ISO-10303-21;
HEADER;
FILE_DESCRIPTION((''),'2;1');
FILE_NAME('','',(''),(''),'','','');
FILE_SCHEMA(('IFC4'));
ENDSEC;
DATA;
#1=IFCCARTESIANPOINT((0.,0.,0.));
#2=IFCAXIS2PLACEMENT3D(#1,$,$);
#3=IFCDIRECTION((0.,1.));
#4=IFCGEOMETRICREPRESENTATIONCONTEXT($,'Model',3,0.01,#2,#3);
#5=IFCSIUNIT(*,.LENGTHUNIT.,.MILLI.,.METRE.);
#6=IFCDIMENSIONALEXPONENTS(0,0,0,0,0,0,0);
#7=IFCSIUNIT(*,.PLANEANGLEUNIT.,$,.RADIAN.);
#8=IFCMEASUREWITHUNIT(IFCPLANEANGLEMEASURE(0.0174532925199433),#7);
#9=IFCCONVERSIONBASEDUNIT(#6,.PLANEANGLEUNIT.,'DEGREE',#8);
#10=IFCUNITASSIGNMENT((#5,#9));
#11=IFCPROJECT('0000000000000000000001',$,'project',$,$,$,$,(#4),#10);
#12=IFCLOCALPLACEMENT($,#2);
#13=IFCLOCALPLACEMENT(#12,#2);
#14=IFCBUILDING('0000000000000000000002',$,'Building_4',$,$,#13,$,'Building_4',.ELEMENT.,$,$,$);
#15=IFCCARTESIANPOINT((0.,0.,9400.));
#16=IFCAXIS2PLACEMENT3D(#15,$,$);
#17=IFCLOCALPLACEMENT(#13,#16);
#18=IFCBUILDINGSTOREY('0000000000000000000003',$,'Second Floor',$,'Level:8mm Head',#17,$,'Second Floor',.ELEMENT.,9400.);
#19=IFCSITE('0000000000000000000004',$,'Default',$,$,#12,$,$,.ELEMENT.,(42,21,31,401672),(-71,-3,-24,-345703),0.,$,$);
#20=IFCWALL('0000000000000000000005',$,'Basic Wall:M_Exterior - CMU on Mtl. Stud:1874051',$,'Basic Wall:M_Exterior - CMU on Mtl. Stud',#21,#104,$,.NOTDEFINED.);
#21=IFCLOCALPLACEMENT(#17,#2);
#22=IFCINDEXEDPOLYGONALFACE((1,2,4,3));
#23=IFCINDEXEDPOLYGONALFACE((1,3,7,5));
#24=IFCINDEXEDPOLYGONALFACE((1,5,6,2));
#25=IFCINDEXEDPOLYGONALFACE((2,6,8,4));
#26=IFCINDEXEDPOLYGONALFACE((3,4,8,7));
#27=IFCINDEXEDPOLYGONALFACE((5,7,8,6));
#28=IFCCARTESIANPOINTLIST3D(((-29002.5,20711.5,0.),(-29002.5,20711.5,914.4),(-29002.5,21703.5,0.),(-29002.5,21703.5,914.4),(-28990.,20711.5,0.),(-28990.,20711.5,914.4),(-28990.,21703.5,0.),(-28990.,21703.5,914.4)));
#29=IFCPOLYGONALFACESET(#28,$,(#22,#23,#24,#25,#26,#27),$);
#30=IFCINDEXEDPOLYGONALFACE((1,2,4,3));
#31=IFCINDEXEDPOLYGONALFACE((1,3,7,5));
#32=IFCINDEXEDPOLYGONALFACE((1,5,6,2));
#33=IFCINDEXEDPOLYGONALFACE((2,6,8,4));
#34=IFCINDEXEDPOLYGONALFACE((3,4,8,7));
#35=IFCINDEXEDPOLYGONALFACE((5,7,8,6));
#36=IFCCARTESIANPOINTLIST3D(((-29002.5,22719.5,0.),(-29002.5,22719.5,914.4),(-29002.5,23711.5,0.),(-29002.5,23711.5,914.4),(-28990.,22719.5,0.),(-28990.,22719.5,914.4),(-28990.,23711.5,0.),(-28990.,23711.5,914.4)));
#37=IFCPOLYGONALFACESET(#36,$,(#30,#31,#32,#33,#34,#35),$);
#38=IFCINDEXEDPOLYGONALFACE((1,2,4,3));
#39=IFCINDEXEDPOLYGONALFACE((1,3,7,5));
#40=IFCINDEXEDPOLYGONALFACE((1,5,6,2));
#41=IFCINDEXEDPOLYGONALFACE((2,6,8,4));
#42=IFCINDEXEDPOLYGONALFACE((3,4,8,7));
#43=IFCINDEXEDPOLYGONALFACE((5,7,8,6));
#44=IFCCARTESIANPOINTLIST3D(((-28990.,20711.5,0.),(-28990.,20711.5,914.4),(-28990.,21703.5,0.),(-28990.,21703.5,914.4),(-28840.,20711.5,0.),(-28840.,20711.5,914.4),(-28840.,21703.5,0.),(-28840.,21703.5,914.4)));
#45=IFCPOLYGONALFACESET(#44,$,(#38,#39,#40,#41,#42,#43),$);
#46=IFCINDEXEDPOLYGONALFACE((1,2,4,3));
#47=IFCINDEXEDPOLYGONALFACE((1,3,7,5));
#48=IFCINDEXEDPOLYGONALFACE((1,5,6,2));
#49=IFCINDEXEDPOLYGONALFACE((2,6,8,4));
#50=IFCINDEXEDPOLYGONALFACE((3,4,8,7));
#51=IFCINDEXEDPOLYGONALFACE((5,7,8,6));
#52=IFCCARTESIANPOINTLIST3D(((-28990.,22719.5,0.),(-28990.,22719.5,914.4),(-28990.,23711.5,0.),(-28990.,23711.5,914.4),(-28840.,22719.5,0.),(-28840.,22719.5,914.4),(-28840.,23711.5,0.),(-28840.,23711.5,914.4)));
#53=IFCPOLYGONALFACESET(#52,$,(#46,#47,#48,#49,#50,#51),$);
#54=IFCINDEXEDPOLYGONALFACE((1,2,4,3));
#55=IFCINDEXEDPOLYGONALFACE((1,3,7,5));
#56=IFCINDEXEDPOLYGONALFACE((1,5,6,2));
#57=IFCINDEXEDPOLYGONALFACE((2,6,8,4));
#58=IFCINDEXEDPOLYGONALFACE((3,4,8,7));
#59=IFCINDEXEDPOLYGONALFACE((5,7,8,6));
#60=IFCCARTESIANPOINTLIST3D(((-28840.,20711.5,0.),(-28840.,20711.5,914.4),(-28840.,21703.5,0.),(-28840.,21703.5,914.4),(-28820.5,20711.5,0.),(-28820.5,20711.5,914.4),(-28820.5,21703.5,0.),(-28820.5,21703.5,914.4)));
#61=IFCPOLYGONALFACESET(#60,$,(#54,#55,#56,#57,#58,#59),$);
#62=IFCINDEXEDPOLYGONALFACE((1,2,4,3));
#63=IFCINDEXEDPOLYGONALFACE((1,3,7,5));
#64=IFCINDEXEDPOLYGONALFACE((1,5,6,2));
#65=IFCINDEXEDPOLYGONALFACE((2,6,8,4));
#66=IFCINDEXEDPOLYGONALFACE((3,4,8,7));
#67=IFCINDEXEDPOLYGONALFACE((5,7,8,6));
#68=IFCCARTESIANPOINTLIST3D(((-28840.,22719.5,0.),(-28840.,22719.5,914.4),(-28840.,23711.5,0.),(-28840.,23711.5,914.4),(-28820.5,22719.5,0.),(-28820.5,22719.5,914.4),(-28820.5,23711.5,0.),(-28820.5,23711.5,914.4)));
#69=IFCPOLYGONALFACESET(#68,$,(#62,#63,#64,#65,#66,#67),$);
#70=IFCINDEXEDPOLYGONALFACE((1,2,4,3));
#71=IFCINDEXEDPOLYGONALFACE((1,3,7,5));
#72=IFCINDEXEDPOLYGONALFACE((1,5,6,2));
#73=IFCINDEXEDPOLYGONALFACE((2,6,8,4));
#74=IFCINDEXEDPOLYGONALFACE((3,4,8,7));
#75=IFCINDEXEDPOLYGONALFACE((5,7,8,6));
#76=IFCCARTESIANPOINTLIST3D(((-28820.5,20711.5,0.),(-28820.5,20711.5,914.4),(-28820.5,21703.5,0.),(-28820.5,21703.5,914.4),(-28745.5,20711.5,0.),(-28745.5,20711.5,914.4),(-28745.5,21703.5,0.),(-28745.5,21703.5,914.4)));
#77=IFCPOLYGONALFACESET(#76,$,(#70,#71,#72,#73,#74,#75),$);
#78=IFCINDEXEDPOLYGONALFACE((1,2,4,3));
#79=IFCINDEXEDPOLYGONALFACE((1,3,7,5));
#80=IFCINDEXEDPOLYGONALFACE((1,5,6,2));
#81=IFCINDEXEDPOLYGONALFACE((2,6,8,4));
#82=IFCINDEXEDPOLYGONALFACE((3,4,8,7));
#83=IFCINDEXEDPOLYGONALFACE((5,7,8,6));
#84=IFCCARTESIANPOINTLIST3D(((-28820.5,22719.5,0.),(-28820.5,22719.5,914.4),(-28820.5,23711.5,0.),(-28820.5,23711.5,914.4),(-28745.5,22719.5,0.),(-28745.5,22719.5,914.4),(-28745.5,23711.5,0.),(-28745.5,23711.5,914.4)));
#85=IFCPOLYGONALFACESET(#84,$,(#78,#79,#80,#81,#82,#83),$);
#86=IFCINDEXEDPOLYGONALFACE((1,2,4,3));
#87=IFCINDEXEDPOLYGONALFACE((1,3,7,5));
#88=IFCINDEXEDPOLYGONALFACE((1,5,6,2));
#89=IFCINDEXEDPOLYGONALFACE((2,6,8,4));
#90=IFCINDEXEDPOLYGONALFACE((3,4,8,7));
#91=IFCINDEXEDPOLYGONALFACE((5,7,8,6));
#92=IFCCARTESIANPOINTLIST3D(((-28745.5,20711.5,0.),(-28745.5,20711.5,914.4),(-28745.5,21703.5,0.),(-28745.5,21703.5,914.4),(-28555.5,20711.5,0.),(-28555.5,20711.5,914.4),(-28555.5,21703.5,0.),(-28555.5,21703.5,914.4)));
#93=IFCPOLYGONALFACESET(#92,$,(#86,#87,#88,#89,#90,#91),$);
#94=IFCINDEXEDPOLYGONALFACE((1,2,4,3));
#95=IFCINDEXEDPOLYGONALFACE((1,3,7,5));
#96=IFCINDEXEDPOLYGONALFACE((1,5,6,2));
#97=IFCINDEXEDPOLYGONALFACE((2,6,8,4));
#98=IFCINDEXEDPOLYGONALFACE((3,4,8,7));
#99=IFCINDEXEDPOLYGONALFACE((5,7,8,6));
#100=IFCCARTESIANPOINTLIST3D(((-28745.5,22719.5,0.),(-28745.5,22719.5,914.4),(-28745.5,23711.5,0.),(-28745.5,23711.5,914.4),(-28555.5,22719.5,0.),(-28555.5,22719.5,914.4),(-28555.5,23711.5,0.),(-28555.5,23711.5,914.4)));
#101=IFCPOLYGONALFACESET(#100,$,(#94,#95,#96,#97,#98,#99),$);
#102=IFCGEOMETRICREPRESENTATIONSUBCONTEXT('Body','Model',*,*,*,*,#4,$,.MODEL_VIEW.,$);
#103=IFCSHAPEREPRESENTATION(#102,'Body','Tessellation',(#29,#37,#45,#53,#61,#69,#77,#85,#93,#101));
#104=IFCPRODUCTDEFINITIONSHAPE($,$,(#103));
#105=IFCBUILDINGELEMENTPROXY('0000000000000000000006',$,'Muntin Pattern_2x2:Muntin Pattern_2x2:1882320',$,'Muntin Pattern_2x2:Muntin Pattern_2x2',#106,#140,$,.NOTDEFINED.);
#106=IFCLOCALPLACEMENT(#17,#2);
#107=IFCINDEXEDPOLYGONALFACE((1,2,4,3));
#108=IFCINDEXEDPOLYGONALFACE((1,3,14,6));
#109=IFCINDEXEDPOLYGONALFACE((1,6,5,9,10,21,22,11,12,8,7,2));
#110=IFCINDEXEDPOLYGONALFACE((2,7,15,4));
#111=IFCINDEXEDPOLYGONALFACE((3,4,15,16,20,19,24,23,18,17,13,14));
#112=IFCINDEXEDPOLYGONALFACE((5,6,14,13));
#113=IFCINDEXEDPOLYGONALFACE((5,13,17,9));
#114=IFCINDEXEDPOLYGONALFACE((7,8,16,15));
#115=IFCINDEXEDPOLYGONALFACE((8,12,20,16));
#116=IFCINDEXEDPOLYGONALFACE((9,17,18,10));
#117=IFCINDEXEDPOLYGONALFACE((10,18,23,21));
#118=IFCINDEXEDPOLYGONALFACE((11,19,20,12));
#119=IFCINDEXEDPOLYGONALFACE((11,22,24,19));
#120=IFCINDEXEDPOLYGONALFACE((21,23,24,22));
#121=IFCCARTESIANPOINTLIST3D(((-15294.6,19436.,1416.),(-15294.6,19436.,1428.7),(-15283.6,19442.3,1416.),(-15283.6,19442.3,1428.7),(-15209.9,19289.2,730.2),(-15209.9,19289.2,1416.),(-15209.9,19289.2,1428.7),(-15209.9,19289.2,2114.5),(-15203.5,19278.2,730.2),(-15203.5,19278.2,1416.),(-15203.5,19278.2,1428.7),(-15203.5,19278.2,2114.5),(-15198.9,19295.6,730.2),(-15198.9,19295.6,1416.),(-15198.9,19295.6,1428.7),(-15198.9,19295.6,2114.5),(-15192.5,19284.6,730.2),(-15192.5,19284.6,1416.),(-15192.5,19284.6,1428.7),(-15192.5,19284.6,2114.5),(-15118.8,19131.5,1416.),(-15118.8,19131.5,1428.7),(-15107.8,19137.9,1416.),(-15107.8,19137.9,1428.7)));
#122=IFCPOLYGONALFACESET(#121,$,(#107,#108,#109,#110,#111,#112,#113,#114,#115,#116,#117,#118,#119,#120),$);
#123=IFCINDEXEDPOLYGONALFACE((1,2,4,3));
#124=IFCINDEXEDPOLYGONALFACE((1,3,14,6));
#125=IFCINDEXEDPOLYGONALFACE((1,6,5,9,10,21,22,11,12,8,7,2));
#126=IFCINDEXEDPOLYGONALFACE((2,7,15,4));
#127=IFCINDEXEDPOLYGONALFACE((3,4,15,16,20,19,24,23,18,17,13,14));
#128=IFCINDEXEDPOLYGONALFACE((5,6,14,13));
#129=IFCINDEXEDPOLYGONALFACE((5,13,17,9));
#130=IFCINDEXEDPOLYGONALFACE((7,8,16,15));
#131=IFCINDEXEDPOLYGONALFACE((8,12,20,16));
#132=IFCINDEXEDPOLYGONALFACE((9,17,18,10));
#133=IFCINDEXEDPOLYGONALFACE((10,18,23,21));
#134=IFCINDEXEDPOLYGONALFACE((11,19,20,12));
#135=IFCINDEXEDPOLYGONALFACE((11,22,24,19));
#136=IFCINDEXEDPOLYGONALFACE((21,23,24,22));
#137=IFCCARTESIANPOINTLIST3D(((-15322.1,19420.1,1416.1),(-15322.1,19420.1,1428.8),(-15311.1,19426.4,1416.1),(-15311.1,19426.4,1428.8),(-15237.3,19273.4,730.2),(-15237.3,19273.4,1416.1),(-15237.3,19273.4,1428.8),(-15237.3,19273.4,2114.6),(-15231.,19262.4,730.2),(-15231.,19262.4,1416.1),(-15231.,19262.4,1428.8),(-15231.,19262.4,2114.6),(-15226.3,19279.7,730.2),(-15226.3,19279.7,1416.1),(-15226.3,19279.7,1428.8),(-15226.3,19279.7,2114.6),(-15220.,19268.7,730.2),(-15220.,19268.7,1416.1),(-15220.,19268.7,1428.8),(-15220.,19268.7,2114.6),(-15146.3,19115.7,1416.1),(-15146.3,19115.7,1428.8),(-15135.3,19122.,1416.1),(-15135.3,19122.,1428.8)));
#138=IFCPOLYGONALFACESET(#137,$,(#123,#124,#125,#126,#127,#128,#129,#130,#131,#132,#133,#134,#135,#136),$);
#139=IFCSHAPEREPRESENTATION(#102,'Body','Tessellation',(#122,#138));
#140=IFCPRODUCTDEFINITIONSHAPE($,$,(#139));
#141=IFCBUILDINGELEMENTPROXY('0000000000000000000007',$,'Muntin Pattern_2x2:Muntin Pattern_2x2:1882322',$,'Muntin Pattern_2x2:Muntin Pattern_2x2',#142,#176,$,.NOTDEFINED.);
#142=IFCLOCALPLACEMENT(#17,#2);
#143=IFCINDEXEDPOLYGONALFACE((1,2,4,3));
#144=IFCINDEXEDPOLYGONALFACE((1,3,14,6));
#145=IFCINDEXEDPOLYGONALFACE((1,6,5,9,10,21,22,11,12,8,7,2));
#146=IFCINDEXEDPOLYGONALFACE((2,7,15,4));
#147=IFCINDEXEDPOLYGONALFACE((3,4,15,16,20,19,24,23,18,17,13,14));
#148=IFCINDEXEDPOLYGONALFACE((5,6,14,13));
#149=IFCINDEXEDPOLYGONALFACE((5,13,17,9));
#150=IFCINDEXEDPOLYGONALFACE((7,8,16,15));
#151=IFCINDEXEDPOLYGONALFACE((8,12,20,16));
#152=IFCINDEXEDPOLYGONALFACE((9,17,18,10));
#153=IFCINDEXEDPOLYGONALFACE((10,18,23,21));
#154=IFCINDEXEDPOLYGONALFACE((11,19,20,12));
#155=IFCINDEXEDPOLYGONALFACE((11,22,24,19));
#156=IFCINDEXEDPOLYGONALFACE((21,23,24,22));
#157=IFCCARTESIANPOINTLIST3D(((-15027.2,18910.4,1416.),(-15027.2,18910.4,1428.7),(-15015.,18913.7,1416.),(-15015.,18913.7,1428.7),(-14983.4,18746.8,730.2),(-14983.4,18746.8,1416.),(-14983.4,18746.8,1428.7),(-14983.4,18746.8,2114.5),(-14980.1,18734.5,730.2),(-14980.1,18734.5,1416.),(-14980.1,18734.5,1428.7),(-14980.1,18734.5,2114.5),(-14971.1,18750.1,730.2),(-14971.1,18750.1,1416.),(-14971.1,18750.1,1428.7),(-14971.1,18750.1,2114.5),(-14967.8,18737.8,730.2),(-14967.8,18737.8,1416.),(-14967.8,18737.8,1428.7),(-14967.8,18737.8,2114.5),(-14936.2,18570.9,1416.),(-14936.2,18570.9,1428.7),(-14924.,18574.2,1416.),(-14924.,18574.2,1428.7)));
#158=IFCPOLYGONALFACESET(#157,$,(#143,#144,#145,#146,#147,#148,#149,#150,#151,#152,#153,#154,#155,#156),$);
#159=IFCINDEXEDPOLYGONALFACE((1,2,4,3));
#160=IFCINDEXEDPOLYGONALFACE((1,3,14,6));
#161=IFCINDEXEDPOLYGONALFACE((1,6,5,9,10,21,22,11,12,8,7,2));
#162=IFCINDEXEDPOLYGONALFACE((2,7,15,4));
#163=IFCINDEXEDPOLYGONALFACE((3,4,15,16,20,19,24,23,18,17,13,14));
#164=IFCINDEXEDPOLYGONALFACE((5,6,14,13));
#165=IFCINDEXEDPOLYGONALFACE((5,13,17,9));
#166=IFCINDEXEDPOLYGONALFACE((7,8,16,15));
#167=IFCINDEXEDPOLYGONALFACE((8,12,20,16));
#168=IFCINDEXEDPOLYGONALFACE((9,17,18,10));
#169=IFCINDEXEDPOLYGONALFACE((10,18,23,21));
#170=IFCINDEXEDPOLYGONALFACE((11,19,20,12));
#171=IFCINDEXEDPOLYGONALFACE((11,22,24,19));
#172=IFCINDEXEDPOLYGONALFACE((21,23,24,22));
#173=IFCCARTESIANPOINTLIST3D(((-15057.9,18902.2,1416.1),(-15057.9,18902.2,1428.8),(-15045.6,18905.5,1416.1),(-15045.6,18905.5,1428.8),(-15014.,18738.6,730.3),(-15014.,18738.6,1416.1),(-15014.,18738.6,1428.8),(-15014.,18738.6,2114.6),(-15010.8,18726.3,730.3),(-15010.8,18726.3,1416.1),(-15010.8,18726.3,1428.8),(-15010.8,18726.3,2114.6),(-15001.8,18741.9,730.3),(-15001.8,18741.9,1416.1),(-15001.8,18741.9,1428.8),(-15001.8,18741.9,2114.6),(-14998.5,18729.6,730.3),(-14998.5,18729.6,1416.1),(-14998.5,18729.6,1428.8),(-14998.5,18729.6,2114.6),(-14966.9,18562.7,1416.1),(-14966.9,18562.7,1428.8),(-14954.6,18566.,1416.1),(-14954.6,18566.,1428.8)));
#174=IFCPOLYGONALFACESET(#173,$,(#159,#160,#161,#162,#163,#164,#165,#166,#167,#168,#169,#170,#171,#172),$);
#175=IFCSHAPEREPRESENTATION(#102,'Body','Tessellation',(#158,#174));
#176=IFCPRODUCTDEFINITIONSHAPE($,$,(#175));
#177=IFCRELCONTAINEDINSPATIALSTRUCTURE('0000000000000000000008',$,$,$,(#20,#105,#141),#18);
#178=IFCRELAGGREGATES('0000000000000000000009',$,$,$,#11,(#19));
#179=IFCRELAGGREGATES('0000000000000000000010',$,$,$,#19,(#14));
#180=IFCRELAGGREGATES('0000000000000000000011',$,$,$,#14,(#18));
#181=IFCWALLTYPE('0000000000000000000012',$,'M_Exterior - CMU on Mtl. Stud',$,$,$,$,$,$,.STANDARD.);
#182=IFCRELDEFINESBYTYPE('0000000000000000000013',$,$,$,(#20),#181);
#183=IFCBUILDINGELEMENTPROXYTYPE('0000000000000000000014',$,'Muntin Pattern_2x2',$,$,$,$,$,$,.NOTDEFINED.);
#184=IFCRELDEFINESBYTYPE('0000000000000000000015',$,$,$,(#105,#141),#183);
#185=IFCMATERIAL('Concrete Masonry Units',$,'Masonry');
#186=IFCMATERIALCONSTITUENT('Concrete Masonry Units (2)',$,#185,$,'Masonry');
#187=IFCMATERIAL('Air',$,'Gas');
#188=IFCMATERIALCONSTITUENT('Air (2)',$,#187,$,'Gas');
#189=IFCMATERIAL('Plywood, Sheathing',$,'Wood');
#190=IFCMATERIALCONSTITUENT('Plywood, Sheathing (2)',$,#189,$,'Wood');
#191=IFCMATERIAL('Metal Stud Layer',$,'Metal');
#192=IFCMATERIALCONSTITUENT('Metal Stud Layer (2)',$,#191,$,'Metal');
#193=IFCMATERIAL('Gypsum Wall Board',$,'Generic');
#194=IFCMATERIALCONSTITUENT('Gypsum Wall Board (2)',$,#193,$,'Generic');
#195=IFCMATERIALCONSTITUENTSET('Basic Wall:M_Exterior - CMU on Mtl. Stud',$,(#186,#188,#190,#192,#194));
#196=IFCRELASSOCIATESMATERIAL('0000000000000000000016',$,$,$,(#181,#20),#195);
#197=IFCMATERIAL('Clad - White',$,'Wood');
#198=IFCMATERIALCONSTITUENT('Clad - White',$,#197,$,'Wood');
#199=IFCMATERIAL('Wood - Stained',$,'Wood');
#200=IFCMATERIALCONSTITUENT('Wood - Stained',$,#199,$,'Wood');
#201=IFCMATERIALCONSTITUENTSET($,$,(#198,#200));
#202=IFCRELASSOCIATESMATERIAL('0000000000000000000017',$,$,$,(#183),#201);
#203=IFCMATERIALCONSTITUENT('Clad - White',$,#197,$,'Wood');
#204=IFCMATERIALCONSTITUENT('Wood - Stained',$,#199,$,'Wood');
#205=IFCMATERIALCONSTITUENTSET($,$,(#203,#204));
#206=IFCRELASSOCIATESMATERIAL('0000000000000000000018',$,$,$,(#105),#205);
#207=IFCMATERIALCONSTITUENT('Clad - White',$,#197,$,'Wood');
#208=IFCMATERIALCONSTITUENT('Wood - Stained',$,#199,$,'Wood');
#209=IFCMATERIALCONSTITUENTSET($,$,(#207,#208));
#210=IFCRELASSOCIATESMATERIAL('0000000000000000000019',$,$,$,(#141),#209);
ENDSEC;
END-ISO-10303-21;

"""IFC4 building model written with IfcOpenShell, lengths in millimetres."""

from ifc_helpers import new_model, entity, si_unit, converted_unit, direction, frame, origin, place, context, subcontext, project, spatial, indexed_curve, outline, extrude, source, transform, mapped, material, constituent, constituent_set, type_object, type_shapes, element, save


model = new_model("IFC4")

# Units and contexts
model_context = context("Model", 3, precision=0.01, world=origin(), true_north=direction((0.0, 1.0)))
body_context = subcontext(model_context, "Body", "Model", "MODEL_VIEW")
ifc_project = project(units=[si_unit("LENGTHUNIT", "METRE", prefix="MILLI"), converted_unit("PLANEANGLEUNIT", "DEGREE", entity("IfcPlaneAngleMeasure", 0.0174532925199433), si_unit("PLANEANGLEUNIT", "RADIAN"), dimensions=[0, 0, 0, 0, 0, 0, 0])], contexts=[model_context])

# Site, building, storey
site_placement = place(None, origin())
site = spatial("IfcSite", under=ifc_project, at=site_placement, Name="Default", CompositionType="ELEMENT", RefLatitude=(42, 21, 31, 401672), RefLongitude=(-71, -3, -24, -345703), RefElevation=0.0)
building_placement = place(site_placement, origin())
building = spatial("IfcBuilding", under=site, at=building_placement, Name="Building_4", LongName="Building_4", CompositionType="ELEMENT")
storey_placement = place(building_placement, frame((0.0, 0.0, 9400.0)))
storey = spatial("IfcBuildingStorey", under=building, at=storey_placement, Name="Second Floor", ObjectType="Level:8mm Head", LongName="Second Floor", CompositionType="ELEMENT", Elevation=9400.0)

# Shared definitions
ifc_material_1 = material(Name="Air", Category="Gas")
ifc_material_2 = material(Name="Plywood, Sheathing", Category="Wood")
ifc_material_3 = material(Name="Metal Stud Layer", Category="Metal")
ifc_material_4 = material(Name="Gypsum Wall Board", Category="Generic")

# Wall, opening
ifc_material_5 = material(Name="Concrete Masonry Units", Category="Masonry")
ifc_constituent_1 = constituent(ifc_material_5, Name="Concrete Masonry Units (2)", Category="Masonry")
ifc_constituent_2 = constituent(ifc_material_1, Name="Air (2)", Category="Gas")
ifc_constituent_3 = constituent(ifc_material_2, Name="Plywood, Sheathing (2)", Category="Wood")
ifc_constituent_4 = constituent(ifc_material_3, Name="Metal Stud Layer (2)", Category="Metal")
ifc_constituent_5 = constituent(ifc_material_4, Name="Gypsum Wall Board (2)", Category="Generic")
ifc_constituent_set_1 = constituent_set(constituents=[ifc_constituent_1, ifc_constituent_2, ifc_constituent_3, ifc_constituent_4, ifc_constituent_5], Name="Basic Wall:M_Exterior - CMU on Mtl. Stud")
wall_type_1 = type_object("IfcWallType", Name="M_Exterior - CMU on Mtl. Stud", PredefinedType="STANDARD", material=ifc_constituent_set_1)
wall_1_placement = place(storey_placement, frame((-28779.0, 23711.5, 0.0), z_axis=(0.0, 0.0, 1.0), x_axis=(0.0, -1.0, 0.0)))
wall_1 = element("IfcWall", 1, at=wall_1_placement, inside=storey, type_object=wall_type_1, material=ifc_constituent_set_1, Name="Basic Wall:M_Exterior - CMU on Mtl. Stud:1874051", ObjectType="Basic Wall:M_Exterior - CMU on Mtl. Stud", PredefinedType="NOTDEFINED", context=body_context, shape_type="SweptSolid", body=[
    extrude(outline(indexed_curve([(-6.2, -496.0), (6.2, -496.0), (6.2, 496.0), (-6.2, 496.0), (-6.2, -496.0)], self_intersect=False)), frame((2504.0, -217.2, 0.0), z_axis=(0.0, 0.0, 1.0), x_axis=(0.0, 1.0, 0.0)), (0.0, 0.0, 1.0), 914.4),
    extrude(outline(indexed_curve([(-6.2, -496.0), (6.2, -496.0), (6.2, 496.0), (-6.2, 496.0), (-6.2, -496.0)], self_intersect=False)), frame((496.0, -217.2, 0.0), z_axis=(0.0, 0.0, 1.0), x_axis=(0.0, 1.0, 0.0)), (0.0, 0.0, 1.0), 914.4),
    extrude(outline(indexed_curve([(-496.0, -75.0), (496.0, -75.0), (496.0, 75.0), (-496.0, 75.0), (-496.0, -75.0)], self_intersect=False)), frame((2504.0, -136.0, 0.0)), (0.0, 0.0, 1.0), 914.4),
    extrude(outline(indexed_curve([(-496.0, -75.0), (496.0, -75.0), (496.0, 75.0), (-496.0, 75.0), (-496.0, -75.0)], self_intersect=False)), frame((496.0, -136.0, 0.0)), (0.0, 0.0, 1.0), 914.4),
    extrude(outline(indexed_curve([(-496.0, -9.7), (496.0, -9.7), (496.0, 9.8), (-496.0, 9.8), (-496.0, -9.7)], self_intersect=False)), frame((2504.0, -51.3, 0.0)), (0.0, 0.0, 1.0), 914.4),
    extrude(outline(indexed_curve([(-496.0, -9.7), (496.0, -9.7), (496.0, 9.8), (-496.0, 9.8), (-496.0, -9.7)], self_intersect=False)), frame((496.0, -51.3, 0.0)), (0.0, 0.0, 1.0), 914.4),
    extrude(outline(indexed_curve([(-496.0, -37.5), (496.0, -37.5), (496.0, 37.5), (-496.0, 37.5), (-496.0, -37.5)], self_intersect=False)), frame((2504.0, -4.0, 0.0)), (0.0, 0.0, 1.0), 914.4),
    extrude(outline(indexed_curve([(-496.0, -37.5), (496.0, -37.5), (496.0, 37.5), (-496.0, 37.5), (-496.0, -37.5)], self_intersect=False)), frame((496.0, -4.0, 0.0)), (0.0, 0.0, 1.0), 914.4),
    extrude(outline(indexed_curve([(-95.0, -496.0), (95.0, -496.0), (95.0, 496.0), (-95.0, 496.0), (-95.0, -496.0)], self_intersect=False)), frame((2504.0, 128.5, 0.0), z_axis=(0.0, 0.0, 1.0), x_axis=(0.0, -1.0, 0.0)), (0.0, 0.0, 1.0), 914.4),
    extrude(outline(indexed_curve([(-95.0, -496.0), (95.0, -496.0), (95.0, 496.0), (-95.0, 496.0), (-95.0, -496.0)], self_intersect=False)), frame((496.0, 128.5, 0.0), z_axis=(0.0, 0.0, 1.0), x_axis=(0.0, -1.0, 0.0)), (0.0, 0.0, 1.0), 914.4),
])
opening_1_placement = place(wall_1_placement, origin())
element("IfcOpeningElement", 2, at=opening_1_placement, cuts=wall_1, PredefinedType="OPENING", context=body_context, shape_type="SweptSolid", body=[
    extrude(outline(indexed_curve([(-508.0, -1117.6), (508.0, -1117.6), (508.0, 1117.6), (-508.0, 1117.6), (-508.0, -1117.6)], self_intersect=False)), frame((1500.0, -1747.5, 1117.6), z_axis=(0.0, 1.0, 0.0), x_axis=(-1.0, 0.0, 0.0)), (0.0, 0.0, 1.0), 3048.0),
])

# Building element proxies
ifc_material_6 = material(Name="Clad - White", Category="Wood")
ifc_constituent_6 = constituent(ifc_material_6, Name="Clad - White", Category="Wood")
ifc_material_7 = material(Name="Wood - Stained", Category="Wood")
ifc_constituent_7 = constituent(ifc_material_7, Name="Wood - Stained", Category="Wood")
ifc_constituent_set_2 = constituent_set(constituents=[ifc_constituent_6, ifc_constituent_7])
ifc_constituent_8 = constituent(ifc_material_6, Name="Clad - White", Category="Wood")
ifc_constituent_9 = constituent(ifc_material_7, Name="Wood - Stained", Category="Wood")
ifc_constituent_set_3 = constituent_set(constituents=[ifc_constituent_8, ifc_constituent_9])
building_element_proxy_type_1 = type_object("IfcBuildingElementProxyType", Name="Muntin Pattern_2x2", PredefinedType="NOTDEFINED", material=ifc_constituent_set_3)
shared_shape_1 = source(origin(), body_context, "Body", "SweptSolid", [
    extrude(outline(indexed_curve([(6.4, -6.4), (692.1, -6.4), (692.1, 6.3), (6.4, 6.3), (6.4, 175.8), (-6.3, 175.8), (-6.3, 6.3), (-692.2, 6.3), (-692.2, -6.4), (-6.3, -6.4), (-6.3, -175.8), (6.4, -175.8), (6.4, -6.4)], self_intersect=False)), frame((0.0, 9.5, 692.1), z_axis=(0.0, 1.0, 0.0), x_axis=(0.0, 0.0, 1.0)), (0.0, 0.0, 1.0), 12.7),
    extrude(outline(indexed_curve([(6.4, -6.4), (692.1, -6.4), (692.1, 6.3), (6.4, 6.3), (6.4, 175.8), (-6.3, 175.8), (-6.3, 6.3), (-692.2, 6.3), (-692.2, -6.4), (-6.3, -6.4), (-6.3, -175.8), (6.4, -175.8), (6.4, -6.4)], self_intersect=False)), frame((0.0, -22.2, 692.2), z_axis=(0.0, 1.0, 0.0), x_axis=(0.0, 0.0, 1.0)), (0.0, 0.0, 1.0), 12.7),
])
type_shapes(building_element_proxy_type_1, [shared_shape_1])
proxy_1_placement = place(storey_placement, frame((-15214.9, 19279.0, 730.2), z_axis=(0.0, 0.0, 1.0), x_axis=(0.5, -0.866025, 0.0)))
element("IfcBuildingElementProxy", 3, at=proxy_1_placement, inside=storey, type_object=building_element_proxy_type_1, material=ifc_constituent_set_2, Name="Muntin Pattern_2x2:Muntin Pattern_2x2:1882320", ObjectType="Muntin Pattern_2x2:Muntin Pattern_2x2", PredefinedType="NOTDEFINED", context=body_context, shape_type="MappedRepresentation", body=[
    mapped(shared_shape_1, transform((0.0, 0.0, 0.0), scale=1.0)),
])
ifc_constituent_10 = constituent(ifc_material_6, Name="Clad - White", Category="Wood")
ifc_constituent_11 = constituent(ifc_material_7, Name="Wood - Stained", Category="Wood")
ifc_constituent_set_4 = constituent_set(constituents=[ifc_constituent_10, ifc_constituent_11])
proxy_2_placement = place(storey_placement, frame((-14990.9, 18738.2, 730.3), z_axis=(0.0, 0.0, 1.0), x_axis=(0.258819, -0.965926, 0.0)))
element("IfcBuildingElementProxy", 4, at=proxy_2_placement, inside=storey, type_object=building_element_proxy_type_1, material=ifc_constituent_set_4, Name="Muntin Pattern_2x2:Muntin Pattern_2x2:1882322", ObjectType="Muntin Pattern_2x2:Muntin Pattern_2x2", PredefinedType="NOTDEFINED", context=body_context, shape_type="MappedRepresentation", body=[
    mapped(shared_shape_1, transform((0.0, 0.0, 0.0), scale=1.0)),
])

save(model, "model.ifc")
